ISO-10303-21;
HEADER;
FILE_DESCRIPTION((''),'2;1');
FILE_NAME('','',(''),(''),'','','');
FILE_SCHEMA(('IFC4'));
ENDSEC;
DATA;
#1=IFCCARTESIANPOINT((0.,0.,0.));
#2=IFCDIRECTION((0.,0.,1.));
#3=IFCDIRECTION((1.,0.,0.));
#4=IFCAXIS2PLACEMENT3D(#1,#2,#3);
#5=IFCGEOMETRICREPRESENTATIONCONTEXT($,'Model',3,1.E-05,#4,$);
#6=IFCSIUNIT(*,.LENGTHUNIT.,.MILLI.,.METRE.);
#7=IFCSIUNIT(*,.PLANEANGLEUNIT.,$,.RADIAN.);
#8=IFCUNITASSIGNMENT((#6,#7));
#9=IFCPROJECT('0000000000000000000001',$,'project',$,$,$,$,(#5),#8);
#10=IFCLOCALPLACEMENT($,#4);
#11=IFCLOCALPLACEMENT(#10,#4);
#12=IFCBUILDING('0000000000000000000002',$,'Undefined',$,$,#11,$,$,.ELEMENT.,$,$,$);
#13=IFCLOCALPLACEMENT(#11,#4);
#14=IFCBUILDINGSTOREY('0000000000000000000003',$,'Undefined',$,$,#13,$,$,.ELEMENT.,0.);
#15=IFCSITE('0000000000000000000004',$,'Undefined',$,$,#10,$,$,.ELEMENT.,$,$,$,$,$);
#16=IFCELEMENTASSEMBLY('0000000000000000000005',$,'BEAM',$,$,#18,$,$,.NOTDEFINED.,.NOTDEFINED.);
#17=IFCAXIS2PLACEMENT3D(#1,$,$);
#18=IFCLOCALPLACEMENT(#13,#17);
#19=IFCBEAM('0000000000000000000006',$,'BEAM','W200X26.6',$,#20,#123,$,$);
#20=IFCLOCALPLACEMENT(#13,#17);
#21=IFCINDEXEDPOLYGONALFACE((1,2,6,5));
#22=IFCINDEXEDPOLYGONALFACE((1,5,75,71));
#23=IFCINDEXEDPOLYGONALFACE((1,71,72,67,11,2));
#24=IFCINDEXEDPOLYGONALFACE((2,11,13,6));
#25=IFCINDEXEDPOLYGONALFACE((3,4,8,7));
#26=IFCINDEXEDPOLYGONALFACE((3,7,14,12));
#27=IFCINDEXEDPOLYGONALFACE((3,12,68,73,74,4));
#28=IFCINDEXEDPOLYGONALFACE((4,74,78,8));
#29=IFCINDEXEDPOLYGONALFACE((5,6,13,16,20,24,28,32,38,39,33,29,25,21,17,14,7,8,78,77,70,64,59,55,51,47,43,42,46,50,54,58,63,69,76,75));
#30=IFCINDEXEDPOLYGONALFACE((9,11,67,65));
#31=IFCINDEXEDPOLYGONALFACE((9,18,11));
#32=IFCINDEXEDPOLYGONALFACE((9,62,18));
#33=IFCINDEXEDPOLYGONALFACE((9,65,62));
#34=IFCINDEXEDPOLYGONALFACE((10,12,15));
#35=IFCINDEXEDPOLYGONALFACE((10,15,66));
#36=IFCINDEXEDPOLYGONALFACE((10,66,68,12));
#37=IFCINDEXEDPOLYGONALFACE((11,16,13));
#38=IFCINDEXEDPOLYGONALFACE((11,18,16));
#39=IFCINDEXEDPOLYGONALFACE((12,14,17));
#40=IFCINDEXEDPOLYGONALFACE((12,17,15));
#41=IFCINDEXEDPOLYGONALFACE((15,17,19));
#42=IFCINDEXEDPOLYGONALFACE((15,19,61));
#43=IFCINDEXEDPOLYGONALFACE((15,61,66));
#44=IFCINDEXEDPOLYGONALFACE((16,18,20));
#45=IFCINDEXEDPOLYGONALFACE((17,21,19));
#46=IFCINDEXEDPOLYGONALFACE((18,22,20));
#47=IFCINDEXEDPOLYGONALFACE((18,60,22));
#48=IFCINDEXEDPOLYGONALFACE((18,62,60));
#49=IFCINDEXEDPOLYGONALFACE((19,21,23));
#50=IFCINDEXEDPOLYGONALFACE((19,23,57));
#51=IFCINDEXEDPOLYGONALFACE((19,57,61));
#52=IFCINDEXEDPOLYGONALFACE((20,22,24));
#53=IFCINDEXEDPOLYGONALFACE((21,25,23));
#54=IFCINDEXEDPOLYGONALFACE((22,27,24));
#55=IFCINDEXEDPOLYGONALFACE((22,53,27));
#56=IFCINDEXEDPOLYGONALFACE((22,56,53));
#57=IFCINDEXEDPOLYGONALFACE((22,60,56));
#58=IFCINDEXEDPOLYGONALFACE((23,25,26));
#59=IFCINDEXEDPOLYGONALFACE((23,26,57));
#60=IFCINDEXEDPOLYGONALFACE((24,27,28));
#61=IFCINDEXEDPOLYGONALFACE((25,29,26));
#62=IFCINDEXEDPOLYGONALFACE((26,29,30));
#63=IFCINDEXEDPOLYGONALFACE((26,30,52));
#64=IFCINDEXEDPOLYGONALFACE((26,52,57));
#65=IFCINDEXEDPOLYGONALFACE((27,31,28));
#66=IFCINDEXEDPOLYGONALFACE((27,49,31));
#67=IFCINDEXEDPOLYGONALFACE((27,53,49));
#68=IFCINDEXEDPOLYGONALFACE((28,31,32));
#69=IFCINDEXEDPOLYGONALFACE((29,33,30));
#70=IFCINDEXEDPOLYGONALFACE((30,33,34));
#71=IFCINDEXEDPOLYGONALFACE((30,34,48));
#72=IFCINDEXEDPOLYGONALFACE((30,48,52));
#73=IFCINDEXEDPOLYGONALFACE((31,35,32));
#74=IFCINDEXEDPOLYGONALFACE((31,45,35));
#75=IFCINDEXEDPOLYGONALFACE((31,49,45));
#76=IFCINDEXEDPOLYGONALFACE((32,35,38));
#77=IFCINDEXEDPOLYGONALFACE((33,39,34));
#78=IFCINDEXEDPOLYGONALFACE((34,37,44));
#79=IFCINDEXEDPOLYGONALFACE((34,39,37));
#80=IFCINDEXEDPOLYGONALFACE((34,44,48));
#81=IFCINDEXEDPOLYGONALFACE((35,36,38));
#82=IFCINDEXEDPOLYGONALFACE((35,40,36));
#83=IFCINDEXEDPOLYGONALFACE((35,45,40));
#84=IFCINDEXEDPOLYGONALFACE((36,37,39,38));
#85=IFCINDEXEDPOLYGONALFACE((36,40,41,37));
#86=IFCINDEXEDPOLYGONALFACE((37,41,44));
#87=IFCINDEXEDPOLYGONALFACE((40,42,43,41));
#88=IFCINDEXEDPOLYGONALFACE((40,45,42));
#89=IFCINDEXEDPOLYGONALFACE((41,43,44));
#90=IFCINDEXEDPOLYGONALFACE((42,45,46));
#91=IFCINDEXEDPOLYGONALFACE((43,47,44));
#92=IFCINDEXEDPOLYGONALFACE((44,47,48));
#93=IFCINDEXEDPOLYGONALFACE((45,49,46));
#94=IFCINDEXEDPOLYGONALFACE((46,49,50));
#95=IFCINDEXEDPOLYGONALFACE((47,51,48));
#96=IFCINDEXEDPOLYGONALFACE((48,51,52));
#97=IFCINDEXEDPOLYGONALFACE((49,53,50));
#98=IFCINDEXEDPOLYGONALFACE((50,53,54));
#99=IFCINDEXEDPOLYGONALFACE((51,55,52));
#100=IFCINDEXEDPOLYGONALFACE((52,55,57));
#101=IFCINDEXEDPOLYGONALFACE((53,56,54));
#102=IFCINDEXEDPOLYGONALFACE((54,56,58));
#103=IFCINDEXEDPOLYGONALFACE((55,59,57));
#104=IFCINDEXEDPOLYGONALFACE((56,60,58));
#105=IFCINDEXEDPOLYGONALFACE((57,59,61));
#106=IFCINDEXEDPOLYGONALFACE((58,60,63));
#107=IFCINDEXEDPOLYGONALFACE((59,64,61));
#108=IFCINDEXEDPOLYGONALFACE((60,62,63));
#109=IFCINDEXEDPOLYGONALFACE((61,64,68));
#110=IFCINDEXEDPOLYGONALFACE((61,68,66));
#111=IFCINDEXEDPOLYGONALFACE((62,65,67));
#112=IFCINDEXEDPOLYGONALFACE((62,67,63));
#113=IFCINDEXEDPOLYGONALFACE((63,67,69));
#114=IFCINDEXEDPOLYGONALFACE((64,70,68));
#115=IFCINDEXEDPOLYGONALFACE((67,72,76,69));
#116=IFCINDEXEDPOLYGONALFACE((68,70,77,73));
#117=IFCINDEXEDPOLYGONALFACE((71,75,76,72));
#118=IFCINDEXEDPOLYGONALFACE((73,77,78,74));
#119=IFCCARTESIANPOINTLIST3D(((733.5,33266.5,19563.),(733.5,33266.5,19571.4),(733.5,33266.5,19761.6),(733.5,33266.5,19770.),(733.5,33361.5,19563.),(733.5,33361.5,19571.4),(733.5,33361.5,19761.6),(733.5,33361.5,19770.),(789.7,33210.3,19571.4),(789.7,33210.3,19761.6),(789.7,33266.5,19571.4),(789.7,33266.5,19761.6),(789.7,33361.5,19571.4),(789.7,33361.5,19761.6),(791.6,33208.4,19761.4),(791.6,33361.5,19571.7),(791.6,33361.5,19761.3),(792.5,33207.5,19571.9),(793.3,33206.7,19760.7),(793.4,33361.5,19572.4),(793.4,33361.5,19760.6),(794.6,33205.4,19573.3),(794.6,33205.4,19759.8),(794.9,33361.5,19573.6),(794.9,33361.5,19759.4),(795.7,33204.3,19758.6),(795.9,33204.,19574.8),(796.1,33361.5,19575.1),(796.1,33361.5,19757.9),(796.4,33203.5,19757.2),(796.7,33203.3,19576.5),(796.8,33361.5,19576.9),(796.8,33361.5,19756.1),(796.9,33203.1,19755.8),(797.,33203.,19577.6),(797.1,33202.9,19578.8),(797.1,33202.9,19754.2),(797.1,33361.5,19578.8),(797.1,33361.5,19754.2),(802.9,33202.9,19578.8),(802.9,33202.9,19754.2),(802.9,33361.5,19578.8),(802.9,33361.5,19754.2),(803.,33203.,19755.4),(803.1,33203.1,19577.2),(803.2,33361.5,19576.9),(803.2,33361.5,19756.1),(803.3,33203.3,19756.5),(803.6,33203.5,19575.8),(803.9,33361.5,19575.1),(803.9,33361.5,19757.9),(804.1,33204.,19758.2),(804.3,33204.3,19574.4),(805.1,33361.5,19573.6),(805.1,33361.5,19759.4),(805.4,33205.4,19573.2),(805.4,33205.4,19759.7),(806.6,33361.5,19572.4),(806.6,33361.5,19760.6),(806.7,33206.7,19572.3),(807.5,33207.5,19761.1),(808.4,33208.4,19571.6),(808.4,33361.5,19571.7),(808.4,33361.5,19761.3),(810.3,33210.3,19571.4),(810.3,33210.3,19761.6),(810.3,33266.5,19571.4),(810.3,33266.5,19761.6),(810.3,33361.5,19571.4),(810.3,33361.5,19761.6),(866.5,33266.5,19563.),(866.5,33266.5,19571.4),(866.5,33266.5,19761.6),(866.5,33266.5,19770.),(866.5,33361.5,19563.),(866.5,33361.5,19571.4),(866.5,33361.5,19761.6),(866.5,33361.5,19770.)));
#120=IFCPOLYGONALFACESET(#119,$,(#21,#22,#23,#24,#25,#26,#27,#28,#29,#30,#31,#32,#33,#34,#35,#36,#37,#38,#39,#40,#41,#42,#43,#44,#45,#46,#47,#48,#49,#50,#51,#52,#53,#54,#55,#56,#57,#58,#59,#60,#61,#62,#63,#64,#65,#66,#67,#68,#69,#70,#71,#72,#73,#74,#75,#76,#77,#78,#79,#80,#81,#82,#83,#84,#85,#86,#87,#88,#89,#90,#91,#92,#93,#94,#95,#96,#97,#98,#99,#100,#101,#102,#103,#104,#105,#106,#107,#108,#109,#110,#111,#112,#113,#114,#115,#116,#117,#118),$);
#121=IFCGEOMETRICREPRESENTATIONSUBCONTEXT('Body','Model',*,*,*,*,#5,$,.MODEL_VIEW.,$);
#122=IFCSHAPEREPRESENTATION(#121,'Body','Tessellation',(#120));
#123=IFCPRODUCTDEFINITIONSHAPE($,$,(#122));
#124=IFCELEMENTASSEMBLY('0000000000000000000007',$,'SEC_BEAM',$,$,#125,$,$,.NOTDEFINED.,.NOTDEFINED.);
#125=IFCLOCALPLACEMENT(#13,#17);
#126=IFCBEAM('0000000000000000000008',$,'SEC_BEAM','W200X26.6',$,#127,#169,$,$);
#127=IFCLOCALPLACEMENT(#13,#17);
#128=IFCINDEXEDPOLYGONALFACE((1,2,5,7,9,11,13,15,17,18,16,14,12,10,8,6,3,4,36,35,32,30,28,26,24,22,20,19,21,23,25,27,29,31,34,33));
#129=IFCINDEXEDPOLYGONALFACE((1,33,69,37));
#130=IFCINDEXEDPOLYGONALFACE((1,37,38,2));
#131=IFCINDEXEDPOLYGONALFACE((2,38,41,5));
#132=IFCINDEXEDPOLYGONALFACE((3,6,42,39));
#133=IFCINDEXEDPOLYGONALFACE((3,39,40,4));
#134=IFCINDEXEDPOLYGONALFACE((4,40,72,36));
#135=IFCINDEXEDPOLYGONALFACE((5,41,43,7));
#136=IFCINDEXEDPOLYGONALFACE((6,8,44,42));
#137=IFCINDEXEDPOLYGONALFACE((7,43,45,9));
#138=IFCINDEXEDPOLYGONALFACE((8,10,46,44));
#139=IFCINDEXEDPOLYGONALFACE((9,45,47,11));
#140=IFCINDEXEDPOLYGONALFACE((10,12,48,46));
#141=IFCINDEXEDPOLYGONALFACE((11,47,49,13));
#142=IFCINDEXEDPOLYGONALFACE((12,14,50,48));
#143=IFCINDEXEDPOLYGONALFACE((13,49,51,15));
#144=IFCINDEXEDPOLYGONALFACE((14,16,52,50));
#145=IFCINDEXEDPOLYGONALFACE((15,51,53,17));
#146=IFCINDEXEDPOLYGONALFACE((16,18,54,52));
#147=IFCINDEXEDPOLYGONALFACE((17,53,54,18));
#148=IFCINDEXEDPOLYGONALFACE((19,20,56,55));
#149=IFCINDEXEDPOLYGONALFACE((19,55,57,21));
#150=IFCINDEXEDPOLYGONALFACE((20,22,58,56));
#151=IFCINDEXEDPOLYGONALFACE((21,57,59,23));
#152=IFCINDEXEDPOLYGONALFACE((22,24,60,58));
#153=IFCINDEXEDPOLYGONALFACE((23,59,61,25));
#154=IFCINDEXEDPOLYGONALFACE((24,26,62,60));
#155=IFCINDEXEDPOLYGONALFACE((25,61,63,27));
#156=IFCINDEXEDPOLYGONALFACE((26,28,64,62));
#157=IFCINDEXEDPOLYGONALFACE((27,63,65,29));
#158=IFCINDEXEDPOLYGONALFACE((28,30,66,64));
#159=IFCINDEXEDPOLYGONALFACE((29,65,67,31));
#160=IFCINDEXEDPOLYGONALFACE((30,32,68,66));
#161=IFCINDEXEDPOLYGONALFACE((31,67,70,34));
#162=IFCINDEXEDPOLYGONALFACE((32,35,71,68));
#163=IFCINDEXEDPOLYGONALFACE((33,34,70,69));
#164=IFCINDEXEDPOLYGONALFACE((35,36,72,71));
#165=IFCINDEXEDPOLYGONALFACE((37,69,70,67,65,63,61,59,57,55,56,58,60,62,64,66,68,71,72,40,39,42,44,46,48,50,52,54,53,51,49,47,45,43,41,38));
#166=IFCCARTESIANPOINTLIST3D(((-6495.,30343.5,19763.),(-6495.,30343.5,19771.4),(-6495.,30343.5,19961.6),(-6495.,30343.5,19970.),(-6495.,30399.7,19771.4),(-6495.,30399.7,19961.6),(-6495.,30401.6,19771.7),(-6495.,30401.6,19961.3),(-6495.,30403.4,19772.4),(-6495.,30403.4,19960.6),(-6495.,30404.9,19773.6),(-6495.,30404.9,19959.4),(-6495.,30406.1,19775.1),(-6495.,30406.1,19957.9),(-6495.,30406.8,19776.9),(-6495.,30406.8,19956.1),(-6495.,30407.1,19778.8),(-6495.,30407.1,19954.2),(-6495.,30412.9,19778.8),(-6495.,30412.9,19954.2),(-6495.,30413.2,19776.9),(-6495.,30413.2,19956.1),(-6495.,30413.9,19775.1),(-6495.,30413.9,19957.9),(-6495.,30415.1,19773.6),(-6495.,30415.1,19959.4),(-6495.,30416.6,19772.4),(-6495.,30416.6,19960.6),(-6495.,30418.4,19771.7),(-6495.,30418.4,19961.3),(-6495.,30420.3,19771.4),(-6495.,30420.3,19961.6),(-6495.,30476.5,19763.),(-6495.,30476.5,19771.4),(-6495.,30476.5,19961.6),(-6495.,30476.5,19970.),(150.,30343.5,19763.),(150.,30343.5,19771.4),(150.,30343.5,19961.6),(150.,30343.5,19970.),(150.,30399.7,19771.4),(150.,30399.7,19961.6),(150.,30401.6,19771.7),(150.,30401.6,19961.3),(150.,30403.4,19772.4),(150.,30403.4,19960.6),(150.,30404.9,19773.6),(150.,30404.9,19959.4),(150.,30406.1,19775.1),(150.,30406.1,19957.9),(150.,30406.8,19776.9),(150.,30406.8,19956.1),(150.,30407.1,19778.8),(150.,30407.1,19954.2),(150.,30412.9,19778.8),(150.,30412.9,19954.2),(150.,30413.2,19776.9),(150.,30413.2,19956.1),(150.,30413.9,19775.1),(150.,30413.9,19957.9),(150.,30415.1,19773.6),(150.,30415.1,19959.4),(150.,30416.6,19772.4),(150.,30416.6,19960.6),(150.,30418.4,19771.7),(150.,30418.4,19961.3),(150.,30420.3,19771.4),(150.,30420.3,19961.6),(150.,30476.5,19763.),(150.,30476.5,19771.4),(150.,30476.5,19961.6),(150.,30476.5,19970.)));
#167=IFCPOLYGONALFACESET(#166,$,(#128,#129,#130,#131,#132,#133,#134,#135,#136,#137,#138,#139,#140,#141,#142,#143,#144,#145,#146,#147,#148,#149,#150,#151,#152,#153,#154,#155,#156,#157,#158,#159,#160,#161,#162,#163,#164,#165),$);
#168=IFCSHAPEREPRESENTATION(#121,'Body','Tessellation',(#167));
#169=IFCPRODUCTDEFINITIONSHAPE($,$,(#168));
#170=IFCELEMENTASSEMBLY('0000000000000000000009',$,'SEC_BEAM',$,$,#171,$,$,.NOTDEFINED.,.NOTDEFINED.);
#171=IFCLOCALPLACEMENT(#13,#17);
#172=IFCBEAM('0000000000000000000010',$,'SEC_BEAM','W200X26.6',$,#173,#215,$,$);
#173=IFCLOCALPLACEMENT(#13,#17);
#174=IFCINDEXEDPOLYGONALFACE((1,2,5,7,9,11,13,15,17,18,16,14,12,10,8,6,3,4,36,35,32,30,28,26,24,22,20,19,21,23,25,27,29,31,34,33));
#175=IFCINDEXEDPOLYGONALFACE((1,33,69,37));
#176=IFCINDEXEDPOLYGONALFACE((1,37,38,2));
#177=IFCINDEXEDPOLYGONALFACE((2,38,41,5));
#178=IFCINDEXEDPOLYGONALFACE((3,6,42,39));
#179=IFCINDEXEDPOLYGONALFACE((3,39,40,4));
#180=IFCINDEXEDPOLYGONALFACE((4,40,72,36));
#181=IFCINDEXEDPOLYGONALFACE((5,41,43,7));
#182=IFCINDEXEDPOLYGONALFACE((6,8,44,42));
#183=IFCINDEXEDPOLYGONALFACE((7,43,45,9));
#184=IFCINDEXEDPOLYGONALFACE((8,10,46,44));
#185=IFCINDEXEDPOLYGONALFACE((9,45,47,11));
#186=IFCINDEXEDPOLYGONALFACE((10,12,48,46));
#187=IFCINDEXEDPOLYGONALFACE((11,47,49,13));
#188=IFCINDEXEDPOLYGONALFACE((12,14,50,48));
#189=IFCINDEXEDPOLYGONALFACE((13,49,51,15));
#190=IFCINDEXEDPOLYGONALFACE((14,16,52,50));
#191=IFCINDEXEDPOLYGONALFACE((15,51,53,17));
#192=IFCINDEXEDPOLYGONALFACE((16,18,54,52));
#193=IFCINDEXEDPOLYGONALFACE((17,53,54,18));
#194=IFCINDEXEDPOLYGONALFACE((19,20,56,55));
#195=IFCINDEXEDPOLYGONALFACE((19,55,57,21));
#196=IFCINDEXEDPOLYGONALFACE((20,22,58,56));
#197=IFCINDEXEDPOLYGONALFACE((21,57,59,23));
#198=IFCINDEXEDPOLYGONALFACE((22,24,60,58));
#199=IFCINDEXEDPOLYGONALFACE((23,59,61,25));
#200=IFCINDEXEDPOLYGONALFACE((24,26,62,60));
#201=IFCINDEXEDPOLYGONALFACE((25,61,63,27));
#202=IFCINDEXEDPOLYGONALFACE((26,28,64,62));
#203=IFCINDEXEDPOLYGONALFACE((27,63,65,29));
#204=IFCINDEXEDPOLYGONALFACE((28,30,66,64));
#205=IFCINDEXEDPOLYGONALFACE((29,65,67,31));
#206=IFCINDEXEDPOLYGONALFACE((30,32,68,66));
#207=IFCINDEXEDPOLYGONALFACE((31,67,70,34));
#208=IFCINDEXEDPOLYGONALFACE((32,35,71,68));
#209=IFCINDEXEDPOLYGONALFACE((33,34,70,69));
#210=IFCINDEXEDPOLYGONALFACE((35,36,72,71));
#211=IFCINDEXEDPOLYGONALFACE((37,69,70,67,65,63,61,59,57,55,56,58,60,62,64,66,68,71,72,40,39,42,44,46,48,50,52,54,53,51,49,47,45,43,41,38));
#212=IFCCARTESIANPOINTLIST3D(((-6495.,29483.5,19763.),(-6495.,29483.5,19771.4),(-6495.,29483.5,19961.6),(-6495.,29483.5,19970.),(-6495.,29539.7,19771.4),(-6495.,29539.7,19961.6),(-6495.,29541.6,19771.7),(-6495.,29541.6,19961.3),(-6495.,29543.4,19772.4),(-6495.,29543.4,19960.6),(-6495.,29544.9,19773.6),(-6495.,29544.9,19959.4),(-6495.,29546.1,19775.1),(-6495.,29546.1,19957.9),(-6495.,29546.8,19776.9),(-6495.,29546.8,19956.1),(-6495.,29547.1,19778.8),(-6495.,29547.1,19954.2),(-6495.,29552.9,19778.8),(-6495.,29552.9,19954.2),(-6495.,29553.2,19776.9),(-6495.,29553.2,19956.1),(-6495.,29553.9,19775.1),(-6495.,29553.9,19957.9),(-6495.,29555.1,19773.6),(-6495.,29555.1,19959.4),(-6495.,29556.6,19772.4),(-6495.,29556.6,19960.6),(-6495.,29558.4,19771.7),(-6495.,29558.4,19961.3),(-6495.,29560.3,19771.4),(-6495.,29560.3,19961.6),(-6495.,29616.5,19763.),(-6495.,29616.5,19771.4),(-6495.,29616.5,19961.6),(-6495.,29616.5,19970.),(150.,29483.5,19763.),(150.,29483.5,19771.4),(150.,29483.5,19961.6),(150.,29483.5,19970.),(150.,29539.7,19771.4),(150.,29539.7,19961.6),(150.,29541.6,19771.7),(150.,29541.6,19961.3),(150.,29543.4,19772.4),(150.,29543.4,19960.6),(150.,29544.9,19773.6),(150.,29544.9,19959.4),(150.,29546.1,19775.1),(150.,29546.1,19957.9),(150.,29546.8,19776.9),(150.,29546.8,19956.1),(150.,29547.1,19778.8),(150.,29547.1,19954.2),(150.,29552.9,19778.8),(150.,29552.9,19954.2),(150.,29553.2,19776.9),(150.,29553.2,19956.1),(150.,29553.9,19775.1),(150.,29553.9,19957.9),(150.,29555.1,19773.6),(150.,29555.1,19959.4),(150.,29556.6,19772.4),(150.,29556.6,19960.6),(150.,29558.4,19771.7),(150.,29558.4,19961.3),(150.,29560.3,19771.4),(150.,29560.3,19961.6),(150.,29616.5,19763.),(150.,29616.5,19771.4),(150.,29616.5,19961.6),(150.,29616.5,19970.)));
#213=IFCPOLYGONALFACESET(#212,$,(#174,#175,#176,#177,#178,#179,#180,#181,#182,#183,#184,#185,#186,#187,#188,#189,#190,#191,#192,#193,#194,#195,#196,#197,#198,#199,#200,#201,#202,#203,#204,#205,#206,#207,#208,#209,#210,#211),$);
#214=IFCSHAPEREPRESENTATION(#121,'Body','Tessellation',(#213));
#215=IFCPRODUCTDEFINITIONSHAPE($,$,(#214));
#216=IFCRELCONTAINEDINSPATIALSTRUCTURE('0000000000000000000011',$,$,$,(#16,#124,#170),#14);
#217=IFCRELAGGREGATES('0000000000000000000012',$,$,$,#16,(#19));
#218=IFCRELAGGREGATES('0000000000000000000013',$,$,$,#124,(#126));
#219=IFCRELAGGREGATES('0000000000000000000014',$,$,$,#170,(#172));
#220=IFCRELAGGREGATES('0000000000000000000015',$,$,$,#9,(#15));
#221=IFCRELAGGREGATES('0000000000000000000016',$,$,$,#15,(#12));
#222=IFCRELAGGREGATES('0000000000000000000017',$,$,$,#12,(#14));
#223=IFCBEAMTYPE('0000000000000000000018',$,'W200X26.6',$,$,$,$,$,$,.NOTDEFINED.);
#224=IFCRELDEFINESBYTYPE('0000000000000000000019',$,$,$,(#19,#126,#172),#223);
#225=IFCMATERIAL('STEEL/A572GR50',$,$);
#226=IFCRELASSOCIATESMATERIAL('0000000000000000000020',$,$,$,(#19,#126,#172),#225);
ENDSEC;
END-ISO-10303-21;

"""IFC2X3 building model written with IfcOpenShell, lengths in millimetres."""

from ifc_helpers import new_model, si_unit, frame, origin_with_axes, origin_2d_with_axis, place, context, subcontext, project, spatial, i_section, extrude, boolean, clip, halfspace, material, type_object, element, aggregate, save


model = new_model("IFC2X3")

# Units and contexts
model_context = context("Model", 3, precision=1e-05, world=origin_with_axes())
body_context = subcontext(model_context, "Body", "Model", "MODEL_VIEW")
ifc_project = project(units=[si_unit("LENGTHUNIT", "METRE", prefix="MILLI"), si_unit("PLANEANGLEUNIT", "RADIAN")], contexts=[model_context])

# Site, building, storey
site_placement = place(None, origin_with_axes())
site = spatial("IfcSite", under=ifc_project, at=site_placement, Name="Undefined", CompositionType="ELEMENT")
building_placement = place(site_placement, origin_with_axes())
building = spatial("IfcBuilding", under=site, at=building_placement, Name="Undefined", CompositionType="ELEMENT")
storey_placement = place(building_placement, origin_with_axes())
storey = spatial("IfcBuildingStorey", under=building, at=storey_placement, Name="Undefined", CompositionType="ELEMENT", Elevation=0.0)

# Element assemblies, beams
ifc_material_1 = material(Name="STEEL/A572GR50")
assembly_1_placement = place(storey_placement, origin_with_axes())
assembly_1 = element("IfcElementAssembly", 1, at=assembly_1_placement, inside=storey, Name="BEAM", AssemblyPlace="NOTDEFINED", PredefinedType="NOTDEFINED")
beam_type_1 = type_object("IfcBeamType", Name="W200X26.6", PredefinedType="NOTDEFINED")
beam_1_placement = place(assembly_1_placement, frame((800.0, 33361.4, 19666.5), z_axis=(0.0, 0.0, 1.0), x_axis=(0.0, -1.0, 0.0)))
beam_1 = element("IfcBeam", 2, at=beam_1_placement, type_object=beam_type_1, material=ifc_material_1, Name="BEAM", Description="W200X26.6", context=body_context, shape_type="CSG", body=[
    boolean("DIFFERENCE", extrude(i_section(OverallWidth=133.0, OverallDepth=207.0, WebThickness=5.8, FlangeThickness=8.4, FilletRadius=7.4, at=origin_2d_with_axis()), frame((161.4, 0.0, 0.0), z_axis=(-1.0, 0.0, 0.0), x_axis=(0.0, -1.0, 0.0)), (0.0, 0.0, 1.0), 161.4), extrude(i_section(OverallWidth=133.0, OverallDepth=207.0, WebThickness=5.8, FlangeThickness=8.4, FilletRadius=7.4, at=origin_2d_with_axis()), frame((161.5, -800.0, 0.0), z_axis=(0.0, 1.0, 0.0), x_axis=(-1.0, 0.0, 0.0)), (0.0, 0.0, 1.0), 7850.0)),
])
assembly_2_placement = place(storey_placement, origin_with_axes())
assembly_2 = element("IfcElementAssembly", 3, at=assembly_2_placement, inside=storey, Name="SEC_BEAM", AssemblyPlace="NOTDEFINED", PredefinedType="NOTDEFINED")
beam_2_placement = place(assembly_2_placement, frame((0.0, 30410.0, 19866.5), z_axis=(0.0, 0.0, 1.0), x_axis=(-1.0, 0.0, 0.0)))
beam_2 = element("IfcBeam", 4, at=beam_2_placement, type_object=beam_type_1, material=ifc_material_1, Name="SEC_BEAM", Description="W200X26.6", context=body_context, shape_type="Clipping", body=[
    clip(clip(extrude(i_section(OverallWidth=133.0, OverallDepth=207.0, WebThickness=5.8, FlangeThickness=8.4, FilletRadius=7.4, at=origin_2d_with_axis()), frame((6500.0, 0.0, 0.0), z_axis=(-1.0, 0.0, 0.0), x_axis=(0.0, -1.0, 0.0)), (0.0, 0.0, 1.0), 6650.0), halfspace(frame((6495.0, 0.0, 0.0), z_axis=(-1.0, 0.0, 0.0), x_axis=(0.0, 1.0, 0.0)), True)), halfspace(frame((-150.0, 0.0, 0.0), z_axis=(1.0, 0.0, 0.0), x_axis=(0.0, -1.0, 0.0)), True)),
])
assembly_3_placement = place(storey_placement, origin_with_axes())
assembly_3 = element("IfcElementAssembly", 5, at=assembly_3_placement, inside=storey, Name="SEC_BEAM", AssemblyPlace="NOTDEFINED", PredefinedType="NOTDEFINED")
beam_3_placement = place(assembly_3_placement, frame((0.0, 29550.0, 19866.5), z_axis=(0.0, 0.0, 1.0), x_axis=(-1.0, 0.0, 0.0)))
beam_3 = element("IfcBeam", 6, at=beam_3_placement, type_object=beam_type_1, material=ifc_material_1, Name="SEC_BEAM", Description="W200X26.6", context=body_context, shape_type="Clipping", body=[
    clip(clip(extrude(i_section(OverallWidth=133.0, OverallDepth=207.0, WebThickness=5.8, FlangeThickness=8.4, FilletRadius=7.4, at=origin_2d_with_axis()), frame((6500.0, 0.0, 0.0), z_axis=(-1.0, 0.0, 0.0), x_axis=(0.0, -1.0, 0.0)), (0.0, 0.0, 1.0), 6650.0), halfspace(frame((6495.0, 0.0, 0.0), z_axis=(-1.0, 0.0, 0.0), x_axis=(0.0, 1.0, 0.0)), True)), halfspace(frame((-150.0, 0.0, 0.0), z_axis=(1.0, 0.0, 0.0), x_axis=(0.0, -1.0, 0.0)), True)),
])

aggregate(assembly_1, [beam_1])

aggregate(assembly_2, [beam_2])
aggregate(assembly_3, [beam_3])

save(model, "model.ifc")
